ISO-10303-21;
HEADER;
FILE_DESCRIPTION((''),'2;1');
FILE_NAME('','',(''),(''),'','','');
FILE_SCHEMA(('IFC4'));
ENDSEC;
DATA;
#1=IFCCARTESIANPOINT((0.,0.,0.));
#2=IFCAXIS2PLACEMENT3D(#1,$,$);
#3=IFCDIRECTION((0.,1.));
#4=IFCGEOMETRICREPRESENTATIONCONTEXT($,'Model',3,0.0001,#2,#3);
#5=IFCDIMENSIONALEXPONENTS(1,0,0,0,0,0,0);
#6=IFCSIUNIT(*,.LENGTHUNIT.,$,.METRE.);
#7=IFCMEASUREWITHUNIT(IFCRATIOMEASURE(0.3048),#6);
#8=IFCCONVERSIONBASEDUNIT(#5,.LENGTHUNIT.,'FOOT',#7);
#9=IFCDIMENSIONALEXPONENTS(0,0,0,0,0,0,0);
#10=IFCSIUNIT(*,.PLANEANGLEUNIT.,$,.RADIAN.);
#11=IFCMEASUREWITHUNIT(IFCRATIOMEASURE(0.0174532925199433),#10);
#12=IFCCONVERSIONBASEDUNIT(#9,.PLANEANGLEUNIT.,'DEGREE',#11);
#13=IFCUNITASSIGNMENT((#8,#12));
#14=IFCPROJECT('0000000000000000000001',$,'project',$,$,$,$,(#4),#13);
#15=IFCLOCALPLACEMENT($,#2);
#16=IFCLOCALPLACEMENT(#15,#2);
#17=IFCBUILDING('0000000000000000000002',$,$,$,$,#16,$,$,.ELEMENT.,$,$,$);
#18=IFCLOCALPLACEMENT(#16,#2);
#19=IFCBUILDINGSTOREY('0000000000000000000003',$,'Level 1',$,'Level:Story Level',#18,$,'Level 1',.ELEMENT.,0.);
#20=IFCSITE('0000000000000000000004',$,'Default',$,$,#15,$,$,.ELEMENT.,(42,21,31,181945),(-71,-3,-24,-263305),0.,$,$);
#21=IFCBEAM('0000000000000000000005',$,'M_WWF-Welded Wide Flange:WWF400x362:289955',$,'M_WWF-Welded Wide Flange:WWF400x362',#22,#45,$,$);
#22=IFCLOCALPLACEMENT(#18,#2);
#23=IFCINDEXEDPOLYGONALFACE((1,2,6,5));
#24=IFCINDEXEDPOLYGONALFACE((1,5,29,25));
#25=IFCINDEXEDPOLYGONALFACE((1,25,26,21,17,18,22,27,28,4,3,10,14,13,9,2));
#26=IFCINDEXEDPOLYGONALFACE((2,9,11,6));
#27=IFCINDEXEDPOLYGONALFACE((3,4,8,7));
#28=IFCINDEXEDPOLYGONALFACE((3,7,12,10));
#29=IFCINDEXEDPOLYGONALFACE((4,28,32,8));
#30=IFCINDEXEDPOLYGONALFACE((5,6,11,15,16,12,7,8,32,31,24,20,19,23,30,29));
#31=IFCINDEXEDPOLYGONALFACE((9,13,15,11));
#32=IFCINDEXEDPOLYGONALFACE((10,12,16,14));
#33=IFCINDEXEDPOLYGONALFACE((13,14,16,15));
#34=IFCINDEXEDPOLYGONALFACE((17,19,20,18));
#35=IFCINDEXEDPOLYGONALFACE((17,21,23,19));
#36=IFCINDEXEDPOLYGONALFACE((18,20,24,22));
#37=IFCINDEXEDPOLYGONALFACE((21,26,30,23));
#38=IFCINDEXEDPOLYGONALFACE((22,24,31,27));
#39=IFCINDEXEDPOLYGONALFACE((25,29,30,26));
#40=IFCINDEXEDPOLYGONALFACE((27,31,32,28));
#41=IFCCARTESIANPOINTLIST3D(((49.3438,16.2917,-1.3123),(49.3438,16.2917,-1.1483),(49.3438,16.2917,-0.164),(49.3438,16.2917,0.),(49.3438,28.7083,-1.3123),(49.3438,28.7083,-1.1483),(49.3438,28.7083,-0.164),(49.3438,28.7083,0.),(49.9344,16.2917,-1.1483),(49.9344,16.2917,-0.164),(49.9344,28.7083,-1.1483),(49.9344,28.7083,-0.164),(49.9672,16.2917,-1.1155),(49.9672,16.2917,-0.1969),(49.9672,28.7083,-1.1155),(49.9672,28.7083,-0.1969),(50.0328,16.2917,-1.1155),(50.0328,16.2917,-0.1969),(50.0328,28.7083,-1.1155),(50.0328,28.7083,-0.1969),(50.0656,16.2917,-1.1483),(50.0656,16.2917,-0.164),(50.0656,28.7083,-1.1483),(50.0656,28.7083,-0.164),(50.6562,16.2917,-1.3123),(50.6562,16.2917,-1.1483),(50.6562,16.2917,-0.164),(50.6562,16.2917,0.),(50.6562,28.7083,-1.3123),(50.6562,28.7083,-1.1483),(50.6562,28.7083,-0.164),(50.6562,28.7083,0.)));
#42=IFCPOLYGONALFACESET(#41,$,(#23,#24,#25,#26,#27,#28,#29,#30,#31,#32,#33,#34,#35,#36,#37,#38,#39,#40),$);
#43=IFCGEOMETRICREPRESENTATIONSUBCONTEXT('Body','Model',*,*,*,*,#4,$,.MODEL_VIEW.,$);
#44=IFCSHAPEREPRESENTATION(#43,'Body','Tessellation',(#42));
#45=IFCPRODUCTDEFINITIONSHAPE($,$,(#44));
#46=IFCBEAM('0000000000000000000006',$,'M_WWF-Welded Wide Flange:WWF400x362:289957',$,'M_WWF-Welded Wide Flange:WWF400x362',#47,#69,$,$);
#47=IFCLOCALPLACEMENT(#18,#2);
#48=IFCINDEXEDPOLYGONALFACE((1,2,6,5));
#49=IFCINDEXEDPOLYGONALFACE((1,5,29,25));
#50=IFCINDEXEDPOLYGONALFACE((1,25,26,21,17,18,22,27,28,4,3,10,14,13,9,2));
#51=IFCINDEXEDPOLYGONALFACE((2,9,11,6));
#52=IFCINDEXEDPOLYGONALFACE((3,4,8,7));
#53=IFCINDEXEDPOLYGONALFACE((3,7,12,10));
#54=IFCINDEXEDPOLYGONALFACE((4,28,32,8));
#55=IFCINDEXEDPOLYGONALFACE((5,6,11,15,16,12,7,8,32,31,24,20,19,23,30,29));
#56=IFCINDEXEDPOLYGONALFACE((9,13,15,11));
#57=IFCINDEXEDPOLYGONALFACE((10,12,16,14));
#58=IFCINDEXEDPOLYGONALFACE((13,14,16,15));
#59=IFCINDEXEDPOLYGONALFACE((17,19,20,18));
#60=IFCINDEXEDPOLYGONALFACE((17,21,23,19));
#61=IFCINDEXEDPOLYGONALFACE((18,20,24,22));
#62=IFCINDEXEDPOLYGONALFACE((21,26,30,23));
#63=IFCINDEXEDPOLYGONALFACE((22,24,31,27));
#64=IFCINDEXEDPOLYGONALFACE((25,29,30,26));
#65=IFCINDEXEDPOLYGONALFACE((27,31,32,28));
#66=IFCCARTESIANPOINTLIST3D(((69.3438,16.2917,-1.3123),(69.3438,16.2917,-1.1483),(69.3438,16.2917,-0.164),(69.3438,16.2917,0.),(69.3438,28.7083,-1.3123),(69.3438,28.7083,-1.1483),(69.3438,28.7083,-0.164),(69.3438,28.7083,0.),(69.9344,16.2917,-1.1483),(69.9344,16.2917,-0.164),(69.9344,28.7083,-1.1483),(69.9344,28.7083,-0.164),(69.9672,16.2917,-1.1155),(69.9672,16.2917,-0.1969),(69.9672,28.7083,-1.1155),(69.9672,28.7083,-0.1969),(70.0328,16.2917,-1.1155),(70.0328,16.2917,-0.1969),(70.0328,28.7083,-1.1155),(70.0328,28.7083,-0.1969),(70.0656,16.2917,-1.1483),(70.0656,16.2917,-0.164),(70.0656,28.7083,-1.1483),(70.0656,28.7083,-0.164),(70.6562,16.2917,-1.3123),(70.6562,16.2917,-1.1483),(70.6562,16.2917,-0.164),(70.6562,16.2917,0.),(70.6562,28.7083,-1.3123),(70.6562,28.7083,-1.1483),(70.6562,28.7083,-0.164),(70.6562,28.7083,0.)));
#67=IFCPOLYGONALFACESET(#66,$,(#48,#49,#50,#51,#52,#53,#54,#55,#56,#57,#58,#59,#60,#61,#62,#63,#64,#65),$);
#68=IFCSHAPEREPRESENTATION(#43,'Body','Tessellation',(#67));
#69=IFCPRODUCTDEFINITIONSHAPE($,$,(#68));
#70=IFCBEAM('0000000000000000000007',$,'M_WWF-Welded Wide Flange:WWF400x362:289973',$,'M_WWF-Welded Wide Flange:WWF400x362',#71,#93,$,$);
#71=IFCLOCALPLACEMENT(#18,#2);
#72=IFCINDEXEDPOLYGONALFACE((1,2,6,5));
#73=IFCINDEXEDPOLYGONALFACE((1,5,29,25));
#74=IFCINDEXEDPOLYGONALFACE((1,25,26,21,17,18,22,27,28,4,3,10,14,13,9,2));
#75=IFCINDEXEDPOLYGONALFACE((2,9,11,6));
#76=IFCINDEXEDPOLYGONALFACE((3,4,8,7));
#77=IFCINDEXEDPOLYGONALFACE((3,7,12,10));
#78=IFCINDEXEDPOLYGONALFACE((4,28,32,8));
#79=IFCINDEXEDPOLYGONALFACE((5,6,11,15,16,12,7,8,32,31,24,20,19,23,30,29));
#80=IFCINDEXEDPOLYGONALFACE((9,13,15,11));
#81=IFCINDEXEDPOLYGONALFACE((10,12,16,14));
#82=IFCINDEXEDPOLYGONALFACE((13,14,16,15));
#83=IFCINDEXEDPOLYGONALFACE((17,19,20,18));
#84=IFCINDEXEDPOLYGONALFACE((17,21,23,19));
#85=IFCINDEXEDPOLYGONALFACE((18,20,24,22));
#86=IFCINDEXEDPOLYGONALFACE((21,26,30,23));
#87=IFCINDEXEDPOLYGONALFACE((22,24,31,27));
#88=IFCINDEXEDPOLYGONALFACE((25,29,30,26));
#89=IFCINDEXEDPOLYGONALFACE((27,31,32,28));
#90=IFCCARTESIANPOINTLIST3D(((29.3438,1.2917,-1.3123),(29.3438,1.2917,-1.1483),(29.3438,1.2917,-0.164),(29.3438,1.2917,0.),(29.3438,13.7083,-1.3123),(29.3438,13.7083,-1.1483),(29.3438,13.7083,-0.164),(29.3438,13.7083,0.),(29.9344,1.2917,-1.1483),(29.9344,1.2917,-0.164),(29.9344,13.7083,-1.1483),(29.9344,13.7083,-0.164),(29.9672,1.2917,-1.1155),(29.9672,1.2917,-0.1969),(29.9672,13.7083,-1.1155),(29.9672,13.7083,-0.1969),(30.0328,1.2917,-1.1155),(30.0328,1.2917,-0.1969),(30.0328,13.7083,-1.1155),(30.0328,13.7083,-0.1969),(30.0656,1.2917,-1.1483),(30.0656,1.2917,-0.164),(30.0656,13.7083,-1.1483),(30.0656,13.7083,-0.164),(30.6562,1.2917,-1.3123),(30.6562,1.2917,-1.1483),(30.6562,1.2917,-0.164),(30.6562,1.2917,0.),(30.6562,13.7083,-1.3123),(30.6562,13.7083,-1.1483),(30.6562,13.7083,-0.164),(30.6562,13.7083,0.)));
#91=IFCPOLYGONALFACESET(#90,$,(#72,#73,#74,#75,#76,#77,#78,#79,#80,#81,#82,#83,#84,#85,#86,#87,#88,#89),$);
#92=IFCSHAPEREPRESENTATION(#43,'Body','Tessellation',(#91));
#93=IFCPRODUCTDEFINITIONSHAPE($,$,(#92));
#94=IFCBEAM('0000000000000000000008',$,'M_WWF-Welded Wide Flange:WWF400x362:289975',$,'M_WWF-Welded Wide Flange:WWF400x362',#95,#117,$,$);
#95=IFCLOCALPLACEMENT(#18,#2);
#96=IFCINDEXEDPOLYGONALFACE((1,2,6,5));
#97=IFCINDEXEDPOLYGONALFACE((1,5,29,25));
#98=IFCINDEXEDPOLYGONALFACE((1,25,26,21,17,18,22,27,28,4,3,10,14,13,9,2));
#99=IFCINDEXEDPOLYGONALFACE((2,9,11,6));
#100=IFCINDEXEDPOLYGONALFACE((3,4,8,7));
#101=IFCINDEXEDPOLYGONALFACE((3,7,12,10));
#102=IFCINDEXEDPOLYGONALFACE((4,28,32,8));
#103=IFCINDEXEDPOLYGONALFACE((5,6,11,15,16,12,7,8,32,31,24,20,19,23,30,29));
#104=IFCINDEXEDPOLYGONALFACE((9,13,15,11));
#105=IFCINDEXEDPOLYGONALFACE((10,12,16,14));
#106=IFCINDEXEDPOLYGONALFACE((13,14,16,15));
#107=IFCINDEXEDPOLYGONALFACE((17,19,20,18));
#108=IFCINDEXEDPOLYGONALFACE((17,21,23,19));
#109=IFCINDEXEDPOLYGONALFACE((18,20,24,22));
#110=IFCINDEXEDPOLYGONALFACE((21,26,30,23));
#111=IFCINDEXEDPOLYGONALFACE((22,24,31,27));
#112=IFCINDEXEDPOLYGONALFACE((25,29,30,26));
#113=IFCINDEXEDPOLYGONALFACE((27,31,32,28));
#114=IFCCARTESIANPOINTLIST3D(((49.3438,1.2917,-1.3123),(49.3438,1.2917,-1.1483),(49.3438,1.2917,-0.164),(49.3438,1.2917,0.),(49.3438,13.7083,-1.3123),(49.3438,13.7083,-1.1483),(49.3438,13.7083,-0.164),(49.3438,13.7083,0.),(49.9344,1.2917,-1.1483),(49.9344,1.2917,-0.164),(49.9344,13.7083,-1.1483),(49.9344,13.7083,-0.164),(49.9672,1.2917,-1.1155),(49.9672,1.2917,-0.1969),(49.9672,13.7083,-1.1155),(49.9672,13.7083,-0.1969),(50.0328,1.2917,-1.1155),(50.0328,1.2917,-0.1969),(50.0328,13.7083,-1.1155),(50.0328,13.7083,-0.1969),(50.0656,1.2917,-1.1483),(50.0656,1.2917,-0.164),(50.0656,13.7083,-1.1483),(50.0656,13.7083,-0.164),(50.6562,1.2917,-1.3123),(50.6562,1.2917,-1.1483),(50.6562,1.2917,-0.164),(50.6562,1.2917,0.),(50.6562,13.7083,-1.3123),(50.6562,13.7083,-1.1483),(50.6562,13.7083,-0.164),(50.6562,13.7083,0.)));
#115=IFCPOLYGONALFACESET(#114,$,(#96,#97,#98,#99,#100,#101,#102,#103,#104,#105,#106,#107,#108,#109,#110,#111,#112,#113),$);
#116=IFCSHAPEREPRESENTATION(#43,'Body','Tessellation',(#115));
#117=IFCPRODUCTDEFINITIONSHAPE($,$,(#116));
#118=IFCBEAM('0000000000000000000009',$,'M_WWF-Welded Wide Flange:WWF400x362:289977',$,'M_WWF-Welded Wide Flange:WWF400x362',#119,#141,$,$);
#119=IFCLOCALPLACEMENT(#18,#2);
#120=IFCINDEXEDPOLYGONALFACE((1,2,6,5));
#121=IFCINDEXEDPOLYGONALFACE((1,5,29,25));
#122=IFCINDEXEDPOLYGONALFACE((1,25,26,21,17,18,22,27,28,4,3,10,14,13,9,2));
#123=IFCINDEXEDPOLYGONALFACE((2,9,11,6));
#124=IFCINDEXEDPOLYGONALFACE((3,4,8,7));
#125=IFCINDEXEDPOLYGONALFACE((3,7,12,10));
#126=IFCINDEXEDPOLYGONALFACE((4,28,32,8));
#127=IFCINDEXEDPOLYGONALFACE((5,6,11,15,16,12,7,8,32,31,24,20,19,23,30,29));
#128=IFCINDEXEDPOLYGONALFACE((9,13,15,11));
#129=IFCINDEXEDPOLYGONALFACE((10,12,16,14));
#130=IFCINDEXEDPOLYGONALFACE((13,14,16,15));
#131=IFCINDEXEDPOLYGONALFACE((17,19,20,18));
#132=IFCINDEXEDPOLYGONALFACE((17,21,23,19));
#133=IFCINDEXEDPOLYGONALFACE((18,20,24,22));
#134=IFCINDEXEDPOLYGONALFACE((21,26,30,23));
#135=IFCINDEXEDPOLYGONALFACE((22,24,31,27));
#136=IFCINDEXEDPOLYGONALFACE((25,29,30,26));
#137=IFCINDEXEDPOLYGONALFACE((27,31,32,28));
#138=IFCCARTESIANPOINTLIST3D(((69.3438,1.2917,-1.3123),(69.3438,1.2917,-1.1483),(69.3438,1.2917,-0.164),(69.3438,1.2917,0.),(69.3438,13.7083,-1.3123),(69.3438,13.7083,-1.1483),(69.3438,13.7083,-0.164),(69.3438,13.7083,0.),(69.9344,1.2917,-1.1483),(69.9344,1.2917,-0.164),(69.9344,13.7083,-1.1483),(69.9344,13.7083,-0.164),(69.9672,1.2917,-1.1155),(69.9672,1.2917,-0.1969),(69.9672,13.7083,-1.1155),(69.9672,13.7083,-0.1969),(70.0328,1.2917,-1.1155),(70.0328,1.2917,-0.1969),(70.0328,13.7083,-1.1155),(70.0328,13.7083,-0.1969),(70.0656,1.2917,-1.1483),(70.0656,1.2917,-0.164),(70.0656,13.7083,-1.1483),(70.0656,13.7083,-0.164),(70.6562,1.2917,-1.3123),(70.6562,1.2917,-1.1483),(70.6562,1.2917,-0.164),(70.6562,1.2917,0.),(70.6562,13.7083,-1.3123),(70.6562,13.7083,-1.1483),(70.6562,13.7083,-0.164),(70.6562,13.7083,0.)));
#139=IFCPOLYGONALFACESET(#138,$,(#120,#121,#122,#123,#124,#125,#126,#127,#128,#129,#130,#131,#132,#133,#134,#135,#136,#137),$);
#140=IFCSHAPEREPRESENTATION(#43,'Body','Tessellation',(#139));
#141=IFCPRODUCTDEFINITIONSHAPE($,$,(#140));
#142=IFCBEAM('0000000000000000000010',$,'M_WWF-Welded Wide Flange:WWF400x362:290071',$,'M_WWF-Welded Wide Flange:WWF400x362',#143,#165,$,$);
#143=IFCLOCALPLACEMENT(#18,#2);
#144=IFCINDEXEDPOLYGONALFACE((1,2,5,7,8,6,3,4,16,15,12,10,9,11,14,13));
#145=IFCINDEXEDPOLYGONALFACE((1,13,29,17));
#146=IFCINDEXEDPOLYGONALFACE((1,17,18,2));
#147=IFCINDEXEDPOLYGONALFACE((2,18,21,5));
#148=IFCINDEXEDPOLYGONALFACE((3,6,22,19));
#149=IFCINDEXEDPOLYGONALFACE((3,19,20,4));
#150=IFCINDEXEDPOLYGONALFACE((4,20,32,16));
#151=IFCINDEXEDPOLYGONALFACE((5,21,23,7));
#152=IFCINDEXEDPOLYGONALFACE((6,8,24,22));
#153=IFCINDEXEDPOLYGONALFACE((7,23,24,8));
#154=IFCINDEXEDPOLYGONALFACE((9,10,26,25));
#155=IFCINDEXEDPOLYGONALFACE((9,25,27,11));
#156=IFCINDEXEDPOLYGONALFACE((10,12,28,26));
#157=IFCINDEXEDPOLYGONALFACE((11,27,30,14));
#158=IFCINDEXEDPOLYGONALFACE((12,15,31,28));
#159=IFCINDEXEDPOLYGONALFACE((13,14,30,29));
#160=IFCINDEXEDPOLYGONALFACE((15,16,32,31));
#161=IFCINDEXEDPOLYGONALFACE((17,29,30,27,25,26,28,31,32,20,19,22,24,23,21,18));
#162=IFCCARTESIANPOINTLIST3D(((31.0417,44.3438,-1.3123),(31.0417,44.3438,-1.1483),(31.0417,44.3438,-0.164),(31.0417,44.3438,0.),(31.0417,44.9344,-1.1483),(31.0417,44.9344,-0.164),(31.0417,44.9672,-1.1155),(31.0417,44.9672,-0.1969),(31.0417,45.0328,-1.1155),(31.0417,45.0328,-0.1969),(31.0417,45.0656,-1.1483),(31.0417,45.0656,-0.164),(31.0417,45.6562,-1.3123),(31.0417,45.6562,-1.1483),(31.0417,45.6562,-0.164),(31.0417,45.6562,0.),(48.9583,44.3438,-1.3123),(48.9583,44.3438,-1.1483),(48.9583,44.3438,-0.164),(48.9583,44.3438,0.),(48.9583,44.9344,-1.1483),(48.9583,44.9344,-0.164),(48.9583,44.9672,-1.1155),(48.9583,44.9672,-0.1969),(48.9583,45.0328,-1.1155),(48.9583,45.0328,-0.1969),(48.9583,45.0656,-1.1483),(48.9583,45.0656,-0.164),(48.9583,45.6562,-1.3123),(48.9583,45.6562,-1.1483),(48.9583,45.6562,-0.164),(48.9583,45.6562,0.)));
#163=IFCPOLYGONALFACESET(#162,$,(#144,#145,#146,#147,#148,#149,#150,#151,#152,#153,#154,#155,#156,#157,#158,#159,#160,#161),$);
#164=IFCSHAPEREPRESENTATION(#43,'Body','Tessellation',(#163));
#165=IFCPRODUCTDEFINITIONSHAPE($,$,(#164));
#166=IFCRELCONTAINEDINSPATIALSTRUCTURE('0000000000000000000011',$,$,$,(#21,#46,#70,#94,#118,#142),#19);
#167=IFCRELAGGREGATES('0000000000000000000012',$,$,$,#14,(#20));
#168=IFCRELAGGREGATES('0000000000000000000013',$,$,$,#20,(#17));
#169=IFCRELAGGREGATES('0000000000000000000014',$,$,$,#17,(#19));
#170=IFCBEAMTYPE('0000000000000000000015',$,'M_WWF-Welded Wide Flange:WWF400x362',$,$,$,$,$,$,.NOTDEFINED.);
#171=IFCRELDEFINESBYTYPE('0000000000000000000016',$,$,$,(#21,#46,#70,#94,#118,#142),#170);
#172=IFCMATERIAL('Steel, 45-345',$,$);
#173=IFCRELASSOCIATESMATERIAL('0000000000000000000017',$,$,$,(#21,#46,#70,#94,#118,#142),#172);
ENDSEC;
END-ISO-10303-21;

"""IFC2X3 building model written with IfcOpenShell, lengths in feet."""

from ifc_helpers import new_model, entity, si_unit, converted_unit, direction, frame, origin, place, context, subcontext, project, spatial, polyline, outline, extrude, material, type_object, element, save


model = new_model("IFC2X3")

# Units and contexts
model_context = context("Model", 3, precision=0.0001, world=origin(), true_north=direction((0.0, 1.0)))
body_context = subcontext(model_context, "Body", "Model", "MODEL_VIEW")
ifc_project = project(units=[converted_unit("LENGTHUNIT", "FOOT", entity("IfcRatioMeasure", 0.3048), si_unit("LENGTHUNIT", "METRE"), dimensions=[1, 0, 0, 0, 0, 0, 0]), converted_unit("PLANEANGLEUNIT", "DEGREE", entity("IfcRatioMeasure", 0.0174532925199433), si_unit("PLANEANGLEUNIT", "RADIAN"), dimensions=[0, 0, 0, 0, 0, 0, 0])], contexts=[model_context])

# Site, building, storey
site_placement = place(None, origin())
site = spatial("IfcSite", under=ifc_project, at=site_placement, Name="Default", CompositionType="ELEMENT", RefLatitude=(42, 21, 31, 181945), RefLongitude=(-71, -3, -24, -263305), RefElevation=0.0)
building_placement = place(site_placement, origin())
building = spatial("IfcBuilding", under=site, at=building_placement, CompositionType="ELEMENT")
storey_placement = place(building_placement, origin())
storey = spatial("IfcBuildingStorey", under=building, at=storey_placement, Name="Level 1", ObjectType="Level:Story Level", LongName="Level 1", CompositionType="ELEMENT", Elevation=0.0)

# Shared definitions
ifc_material = material(Name="Steel, 45-345")

# Beams
beam_type = type_object("IfcBeamType", Name="M_WWF-Welded Wide Flange:WWF400x362", PredefinedType="NOTDEFINED")
beam_1_placement = place(storey_placement, frame((50.0, 15.0, 0.0), z_axis=(0.0, 0.0, 1.0), x_axis=(0.0, 1.0, 0.0)))
element("IfcBeam", 1, at=beam_1_placement, inside=storey, type_object=beam_type, material=ifc_material, Name="M_WWF-Welded Wide Flange:WWF400x362:289955", ObjectType="M_WWF-Welded Wide Flange:WWF400x362", context=body_context, shape_type="SweptSolid", body=[
    extrude(outline(polyline([(-0.6562, -0.6562), (-0.4921, -0.6562), (-0.4921, -0.0656), (-0.4593, -0.0328), (0.4593, -0.0328), (0.4921, -0.0656), (0.4921, -0.6562), (0.6562, -0.6562), (0.6562, 0.6562), (0.4921, 0.6562), (0.4921, 0.0656), (0.4593, 0.0328), (-0.4593, 0.0328), (-0.4921, 0.0656), (-0.4921, 0.6562), (-0.6562, 0.6562), (-0.6562, -0.6562)])), frame((1.2917, 0.0, -0.6562), z_axis=(1.0, 0.0, 0.0), x_axis=(0.0, 0.0, -1.0)), (0.0, 0.0, 1.0), 12.4167),
])
beam_2_placement = place(storey_placement, frame((70.0, 15.0, 0.0), z_axis=(0.0, 0.0, 1.0), x_axis=(0.0, 1.0, 0.0)))
element("IfcBeam", 2, at=beam_2_placement, inside=storey, type_object=beam_type, material=ifc_material, Name="M_WWF-Welded Wide Flange:WWF400x362:289957", ObjectType="M_WWF-Welded Wide Flange:WWF400x362", context=body_context, shape_type="SweptSolid", body=[
    extrude(outline(polyline([(-0.6562, -0.6562), (-0.4921, -0.6562), (-0.4921, -0.0656), (-0.4593, -0.0328), (0.4593, -0.0328), (0.4921, -0.0656), (0.4921, -0.6562), (0.6562, -0.6562), (0.6562, 0.6562), (0.4921, 0.6562), (0.4921, 0.0656), (0.4593, 0.0328), (-0.4593, 0.0328), (-0.4921, 0.0656), (-0.4921, 0.6562), (-0.6562, 0.6562), (-0.6562, -0.6562)])), frame((1.2917, 0.0, -0.6562), z_axis=(1.0, 0.0, 0.0), x_axis=(0.0, 0.0, -1.0)), (0.0, 0.0, 1.0), 12.4167),
])
beam_3_placement = place(storey_placement, frame((30.0, 0.0, 0.0), z_axis=(0.0, 0.0, 1.0), x_axis=(0.0, 1.0, 0.0)))
element("IfcBeam", 3, at=beam_3_placement, inside=storey, type_object=beam_type, material=ifc_material, Name="M_WWF-Welded Wide Flange:WWF400x362:289973", ObjectType="M_WWF-Welded Wide Flange:WWF400x362", context=body_context, shape_type="SweptSolid", body=[
    extrude(outline(polyline([(-0.6562, -0.6562), (-0.4921, -0.6562), (-0.4921, -0.0656), (-0.4593, -0.0328), (0.4593, -0.0328), (0.4921, -0.0656), (0.4921, -0.6562), (0.6562, -0.6562), (0.6562, 0.6562), (0.4921, 0.6562), (0.4921, 0.0656), (0.4593, 0.0328), (-0.4593, 0.0328), (-0.4921, 0.0656), (-0.4921, 0.6562), (-0.6562, 0.6562), (-0.6562, -0.6562)])), frame((1.2917, 0.0, -0.6562), z_axis=(1.0, 0.0, 0.0), x_axis=(0.0, 0.0, -1.0)), (0.0, 0.0, 1.0), 12.4167),
])
beam_4_placement = place(storey_placement, frame((50.0, 0.0, 0.0), z_axis=(0.0, 0.0, 1.0), x_axis=(0.0, 1.0, 0.0)))
element("IfcBeam", 4, at=beam_4_placement, inside=storey, type_object=beam_type, material=ifc_material, Name="M_WWF-Welded Wide Flange:WWF400x362:289975", ObjectType="M_WWF-Welded Wide Flange:WWF400x362", context=body_context, shape_type="SweptSolid", body=[
    extrude(outline(polyline([(-0.6562, -0.6562), (-0.4921, -0.6562), (-0.4921, -0.0656), (-0.4593, -0.0328), (0.4593, -0.0328), (0.4921, -0.0656), (0.4921, -0.6562), (0.6562, -0.6562), (0.6562, 0.6562), (0.4921, 0.6562), (0.4921, 0.0656), (0.4593, 0.0328), (-0.4593, 0.0328), (-0.4921, 0.0656), (-0.4921, 0.6562), (-0.6562, 0.6562), (-0.6562, -0.6562)])), frame((1.2917, 0.0, -0.6562), z_axis=(1.0, 0.0, 0.0), x_axis=(0.0, 0.0, -1.0)), (0.0, 0.0, 1.0), 12.4167),
])
beam_5_placement = place(storey_placement, frame((70.0, 0.0, 0.0), z_axis=(0.0, 0.0, 1.0), x_axis=(0.0, 1.0, 0.0)))
element("IfcBeam", 5, at=beam_5_placement, inside=storey, type_object=beam_type, material=ifc_material, Name="M_WWF-Welded Wide Flange:WWF400x362:289977", ObjectType="M_WWF-Welded Wide Flange:WWF400x362", context=body_context, shape_type="SweptSolid", body=[
    extrude(outline(polyline([(-0.6562, -0.6562), (-0.4921, -0.6562), (-0.4921, -0.0656), (-0.4593, -0.0328), (0.4593, -0.0328), (0.4921, -0.0656), (0.4921, -0.6562), (0.6562, -0.6562), (0.6562, 0.6562), (0.4921, 0.6562), (0.4921, 0.0656), (0.4593, 0.0328), (-0.4593, 0.0328), (-0.4921, 0.0656), (-0.4921, 0.6562), (-0.6562, 0.6562), (-0.6562, -0.6562)])), frame((1.2917, 0.0, -0.6562), z_axis=(1.0, 0.0, 0.0), x_axis=(0.0, 0.0, -1.0)), (0.0, 0.0, 1.0), 12.4167),
])
beam_6_placement = place(storey_placement, frame((30.0, 45.0, 0.0)))
element("IfcBeam", 6, at=beam_6_placement, inside=storey, type_object=beam_type, material=ifc_material, Name="M_WWF-Welded Wide Flange:WWF400x362:290071", ObjectType="M_WWF-Welded Wide Flange:WWF400x362", context=body_context, shape_type="SweptSolid", body=[
    extrude(outline(polyline([(-0.6562, -0.6562), (-0.4921, -0.6562), (-0.4921, -0.0656), (-0.4593, -0.0328), (0.4593, -0.0328), (0.4921, -0.0656), (0.4921, -0.6562), (0.6562, -0.6562), (0.6562, 0.6562), (0.4921, 0.6562), (0.4921, 0.0656), (0.4593, 0.0328), (-0.4593, 0.0328), (-0.4921, 0.0656), (-0.4921, 0.6562), (-0.6562, 0.6562), (-0.6562, -0.6562)])), frame((1.0417, 0.0, -0.6562), z_axis=(1.0, 0.0, 0.0), x_axis=(0.0, 0.0, -1.0)), (0.0, 0.0, 1.0), 17.9167),
])

save(model, "model.ifc")
